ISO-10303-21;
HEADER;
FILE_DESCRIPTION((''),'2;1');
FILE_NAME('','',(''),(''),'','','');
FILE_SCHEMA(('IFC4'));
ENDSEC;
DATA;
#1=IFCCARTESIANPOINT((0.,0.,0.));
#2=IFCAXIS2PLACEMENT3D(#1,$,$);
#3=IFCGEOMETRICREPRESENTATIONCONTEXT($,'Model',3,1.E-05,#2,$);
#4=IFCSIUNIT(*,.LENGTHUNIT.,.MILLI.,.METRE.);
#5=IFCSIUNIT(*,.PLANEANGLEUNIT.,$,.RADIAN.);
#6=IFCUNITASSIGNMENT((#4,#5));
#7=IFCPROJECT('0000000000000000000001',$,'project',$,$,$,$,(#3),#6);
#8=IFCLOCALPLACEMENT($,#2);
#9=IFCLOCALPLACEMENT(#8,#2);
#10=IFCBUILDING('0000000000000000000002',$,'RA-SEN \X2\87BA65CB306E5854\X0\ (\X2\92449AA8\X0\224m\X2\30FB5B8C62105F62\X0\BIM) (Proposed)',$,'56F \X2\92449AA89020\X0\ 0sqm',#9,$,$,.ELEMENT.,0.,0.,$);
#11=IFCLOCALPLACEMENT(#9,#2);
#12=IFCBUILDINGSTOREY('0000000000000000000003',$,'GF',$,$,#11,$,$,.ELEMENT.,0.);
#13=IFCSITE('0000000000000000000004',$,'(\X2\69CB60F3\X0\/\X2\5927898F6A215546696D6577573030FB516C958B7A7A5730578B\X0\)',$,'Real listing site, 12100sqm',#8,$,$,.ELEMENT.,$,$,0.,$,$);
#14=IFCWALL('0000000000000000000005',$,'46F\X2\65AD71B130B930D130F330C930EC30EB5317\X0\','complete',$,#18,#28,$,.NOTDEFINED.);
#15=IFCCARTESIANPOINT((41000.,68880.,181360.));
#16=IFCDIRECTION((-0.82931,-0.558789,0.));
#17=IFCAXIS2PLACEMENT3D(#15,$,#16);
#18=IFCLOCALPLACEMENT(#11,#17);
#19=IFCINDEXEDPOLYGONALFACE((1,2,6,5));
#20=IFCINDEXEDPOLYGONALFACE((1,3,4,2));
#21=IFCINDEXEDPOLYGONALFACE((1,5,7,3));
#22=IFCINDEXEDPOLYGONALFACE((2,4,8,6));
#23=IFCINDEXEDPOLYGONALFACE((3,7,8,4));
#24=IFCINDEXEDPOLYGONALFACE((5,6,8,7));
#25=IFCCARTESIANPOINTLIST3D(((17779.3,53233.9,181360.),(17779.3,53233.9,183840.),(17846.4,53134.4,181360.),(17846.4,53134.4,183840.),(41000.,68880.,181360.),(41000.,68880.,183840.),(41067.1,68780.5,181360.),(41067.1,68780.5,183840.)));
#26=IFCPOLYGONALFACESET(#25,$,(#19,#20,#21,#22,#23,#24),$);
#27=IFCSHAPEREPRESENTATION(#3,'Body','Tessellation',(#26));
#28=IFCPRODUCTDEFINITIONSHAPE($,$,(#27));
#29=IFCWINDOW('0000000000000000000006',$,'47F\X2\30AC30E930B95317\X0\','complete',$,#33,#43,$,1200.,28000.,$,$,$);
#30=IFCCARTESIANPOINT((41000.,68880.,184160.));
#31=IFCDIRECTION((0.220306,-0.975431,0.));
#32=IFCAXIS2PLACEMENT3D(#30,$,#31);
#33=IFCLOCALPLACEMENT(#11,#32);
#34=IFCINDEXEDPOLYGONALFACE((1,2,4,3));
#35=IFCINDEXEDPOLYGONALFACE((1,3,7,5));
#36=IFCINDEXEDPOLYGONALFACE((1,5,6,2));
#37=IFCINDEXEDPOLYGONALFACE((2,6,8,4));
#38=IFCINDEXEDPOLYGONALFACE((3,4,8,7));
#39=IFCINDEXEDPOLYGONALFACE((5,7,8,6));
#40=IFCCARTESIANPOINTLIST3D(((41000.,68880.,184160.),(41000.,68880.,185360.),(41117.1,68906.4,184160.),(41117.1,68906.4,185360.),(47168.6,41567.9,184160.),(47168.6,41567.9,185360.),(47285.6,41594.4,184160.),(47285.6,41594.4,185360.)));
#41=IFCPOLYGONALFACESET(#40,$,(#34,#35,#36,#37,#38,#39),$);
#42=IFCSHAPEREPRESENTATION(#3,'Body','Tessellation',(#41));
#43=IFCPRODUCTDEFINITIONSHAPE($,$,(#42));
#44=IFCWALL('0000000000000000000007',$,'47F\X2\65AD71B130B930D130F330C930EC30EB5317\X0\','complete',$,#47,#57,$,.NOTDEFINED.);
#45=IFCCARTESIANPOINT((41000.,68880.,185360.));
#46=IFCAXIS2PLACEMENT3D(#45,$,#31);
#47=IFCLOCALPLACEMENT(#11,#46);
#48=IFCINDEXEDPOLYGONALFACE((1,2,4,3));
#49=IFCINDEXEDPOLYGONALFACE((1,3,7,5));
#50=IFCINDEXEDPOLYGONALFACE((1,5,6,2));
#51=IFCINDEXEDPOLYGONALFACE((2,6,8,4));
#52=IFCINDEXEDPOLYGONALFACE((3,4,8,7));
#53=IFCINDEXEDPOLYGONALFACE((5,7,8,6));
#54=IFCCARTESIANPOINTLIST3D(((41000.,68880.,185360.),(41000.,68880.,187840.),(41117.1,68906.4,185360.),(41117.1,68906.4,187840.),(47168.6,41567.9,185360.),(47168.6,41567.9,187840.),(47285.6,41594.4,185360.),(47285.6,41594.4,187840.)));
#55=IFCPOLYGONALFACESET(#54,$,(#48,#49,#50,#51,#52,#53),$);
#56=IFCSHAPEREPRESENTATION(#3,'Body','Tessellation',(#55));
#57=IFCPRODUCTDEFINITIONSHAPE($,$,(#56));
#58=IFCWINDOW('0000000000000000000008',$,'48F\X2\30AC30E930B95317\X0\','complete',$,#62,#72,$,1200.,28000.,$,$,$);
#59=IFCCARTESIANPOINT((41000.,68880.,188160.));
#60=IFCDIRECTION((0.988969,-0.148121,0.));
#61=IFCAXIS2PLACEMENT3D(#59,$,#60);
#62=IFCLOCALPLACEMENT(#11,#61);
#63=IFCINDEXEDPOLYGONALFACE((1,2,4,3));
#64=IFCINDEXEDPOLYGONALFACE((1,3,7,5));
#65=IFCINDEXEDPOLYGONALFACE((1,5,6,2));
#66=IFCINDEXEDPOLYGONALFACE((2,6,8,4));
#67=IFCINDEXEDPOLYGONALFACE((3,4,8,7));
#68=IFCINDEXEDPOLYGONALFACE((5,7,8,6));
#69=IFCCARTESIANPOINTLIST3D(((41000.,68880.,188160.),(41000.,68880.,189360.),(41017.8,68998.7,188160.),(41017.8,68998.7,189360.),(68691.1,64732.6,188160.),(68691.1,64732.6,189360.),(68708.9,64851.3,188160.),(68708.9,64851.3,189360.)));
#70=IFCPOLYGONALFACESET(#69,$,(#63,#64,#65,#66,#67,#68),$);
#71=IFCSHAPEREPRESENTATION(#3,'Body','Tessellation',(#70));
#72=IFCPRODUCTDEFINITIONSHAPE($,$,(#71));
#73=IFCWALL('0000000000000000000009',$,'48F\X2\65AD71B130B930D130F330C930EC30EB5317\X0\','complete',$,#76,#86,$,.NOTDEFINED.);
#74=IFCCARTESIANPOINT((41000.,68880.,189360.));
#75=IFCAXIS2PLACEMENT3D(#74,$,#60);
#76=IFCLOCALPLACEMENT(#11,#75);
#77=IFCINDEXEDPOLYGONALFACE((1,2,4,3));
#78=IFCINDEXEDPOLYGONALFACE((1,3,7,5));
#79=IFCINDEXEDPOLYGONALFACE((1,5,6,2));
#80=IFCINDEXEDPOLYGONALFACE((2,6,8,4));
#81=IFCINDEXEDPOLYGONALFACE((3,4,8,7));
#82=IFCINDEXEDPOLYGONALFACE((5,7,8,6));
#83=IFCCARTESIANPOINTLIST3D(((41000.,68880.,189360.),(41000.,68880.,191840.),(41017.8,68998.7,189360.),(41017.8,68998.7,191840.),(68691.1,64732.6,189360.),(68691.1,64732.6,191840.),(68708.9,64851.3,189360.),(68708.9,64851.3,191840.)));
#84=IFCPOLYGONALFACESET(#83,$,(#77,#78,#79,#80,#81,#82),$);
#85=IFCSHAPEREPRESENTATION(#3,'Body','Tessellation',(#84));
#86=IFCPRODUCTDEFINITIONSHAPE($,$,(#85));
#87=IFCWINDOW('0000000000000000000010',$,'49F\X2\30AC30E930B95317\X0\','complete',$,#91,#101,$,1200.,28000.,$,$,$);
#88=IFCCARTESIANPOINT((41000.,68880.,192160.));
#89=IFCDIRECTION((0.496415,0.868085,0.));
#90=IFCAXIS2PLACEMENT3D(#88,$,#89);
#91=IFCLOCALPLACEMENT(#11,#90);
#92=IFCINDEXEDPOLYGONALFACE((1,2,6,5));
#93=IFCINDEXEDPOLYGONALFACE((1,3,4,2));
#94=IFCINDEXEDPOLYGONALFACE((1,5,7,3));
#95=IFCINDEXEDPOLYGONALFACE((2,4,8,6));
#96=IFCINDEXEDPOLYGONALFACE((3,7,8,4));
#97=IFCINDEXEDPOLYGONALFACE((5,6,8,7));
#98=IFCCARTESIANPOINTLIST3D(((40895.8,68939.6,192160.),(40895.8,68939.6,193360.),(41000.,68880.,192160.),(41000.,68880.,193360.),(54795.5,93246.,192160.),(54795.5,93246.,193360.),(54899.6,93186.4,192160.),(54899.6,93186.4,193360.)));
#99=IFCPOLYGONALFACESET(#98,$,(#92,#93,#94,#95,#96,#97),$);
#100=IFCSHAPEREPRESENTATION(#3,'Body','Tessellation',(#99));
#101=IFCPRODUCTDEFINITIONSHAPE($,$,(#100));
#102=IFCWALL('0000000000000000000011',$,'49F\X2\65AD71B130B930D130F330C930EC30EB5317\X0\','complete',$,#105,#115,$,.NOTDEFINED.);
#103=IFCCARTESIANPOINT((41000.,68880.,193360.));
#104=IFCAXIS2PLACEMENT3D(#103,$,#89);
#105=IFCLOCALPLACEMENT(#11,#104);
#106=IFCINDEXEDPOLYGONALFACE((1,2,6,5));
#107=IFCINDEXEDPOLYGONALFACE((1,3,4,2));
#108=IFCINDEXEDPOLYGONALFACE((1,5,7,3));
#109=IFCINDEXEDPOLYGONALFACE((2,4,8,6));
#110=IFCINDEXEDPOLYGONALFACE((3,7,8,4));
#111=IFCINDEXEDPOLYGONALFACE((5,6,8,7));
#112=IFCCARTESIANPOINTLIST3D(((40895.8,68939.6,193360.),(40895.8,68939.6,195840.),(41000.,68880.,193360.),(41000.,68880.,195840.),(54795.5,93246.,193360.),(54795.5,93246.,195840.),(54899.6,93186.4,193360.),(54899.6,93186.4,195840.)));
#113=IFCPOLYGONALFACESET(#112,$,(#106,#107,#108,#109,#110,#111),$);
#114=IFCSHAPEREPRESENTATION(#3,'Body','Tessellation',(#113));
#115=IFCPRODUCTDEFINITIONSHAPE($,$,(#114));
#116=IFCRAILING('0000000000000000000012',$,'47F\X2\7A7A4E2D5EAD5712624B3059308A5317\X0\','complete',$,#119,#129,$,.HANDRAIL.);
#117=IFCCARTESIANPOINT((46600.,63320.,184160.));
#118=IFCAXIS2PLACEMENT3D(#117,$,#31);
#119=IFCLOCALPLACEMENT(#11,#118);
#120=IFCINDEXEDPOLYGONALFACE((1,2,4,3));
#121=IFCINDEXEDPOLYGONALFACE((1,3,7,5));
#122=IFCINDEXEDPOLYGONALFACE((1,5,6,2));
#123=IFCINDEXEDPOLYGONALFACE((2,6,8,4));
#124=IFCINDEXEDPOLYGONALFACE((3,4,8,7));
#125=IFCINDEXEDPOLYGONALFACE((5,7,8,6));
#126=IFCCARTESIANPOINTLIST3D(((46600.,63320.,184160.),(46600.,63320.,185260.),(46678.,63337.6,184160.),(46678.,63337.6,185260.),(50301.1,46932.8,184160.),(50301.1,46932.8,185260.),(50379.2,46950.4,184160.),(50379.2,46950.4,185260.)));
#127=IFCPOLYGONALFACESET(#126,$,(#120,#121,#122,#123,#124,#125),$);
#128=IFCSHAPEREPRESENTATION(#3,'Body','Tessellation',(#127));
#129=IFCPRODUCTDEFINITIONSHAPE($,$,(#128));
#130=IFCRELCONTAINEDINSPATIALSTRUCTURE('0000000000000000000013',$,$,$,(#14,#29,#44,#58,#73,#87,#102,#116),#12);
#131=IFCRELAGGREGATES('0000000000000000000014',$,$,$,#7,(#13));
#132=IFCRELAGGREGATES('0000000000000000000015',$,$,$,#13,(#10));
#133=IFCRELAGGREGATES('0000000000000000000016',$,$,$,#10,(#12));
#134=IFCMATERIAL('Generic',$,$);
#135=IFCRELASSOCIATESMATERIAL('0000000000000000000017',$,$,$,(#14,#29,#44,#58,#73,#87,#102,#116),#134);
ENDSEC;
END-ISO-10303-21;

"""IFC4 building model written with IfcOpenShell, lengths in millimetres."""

from ifc_helpers import new_model, si_unit, frame, frame_2d, origin, place, context, project, spatial, rectangle, extrude, material, element, save


model = new_model("IFC4")

# Units and contexts
model_context = context("Model", 3, precision=1e-05, world=origin())
ifc_project = project(units=[si_unit("LENGTHUNIT", "METRE", prefix="MILLI"), si_unit("PLANEANGLEUNIT", "RADIAN")], contexts=[model_context])

# Site, building, storey
site_placement = place(None, origin())
site = spatial("IfcSite", under=ifc_project, at=site_placement, Name="(構想/大規模商業敷地・公開空地型)", ObjectType="Real listing site, 12100sqm", CompositionType="ELEMENT", RefElevation=0.0)
building_placement = place(site_placement, origin())
building = spatial("IfcBuilding", under=site, at=building_placement, Name="RA-SEN 螺旋の塔 (鉄骨224m・完成形BIM) (Proposed)", ObjectType="56F 鉄骨造 0sqm", CompositionType="ELEMENT", ElevationOfRefHeight=0.0, ElevationOfTerrain=0.0)
storey_placement = place(building_placement, origin())
storey = spatial("IfcBuildingStorey", under=building, at=storey_placement, Name="GF", CompositionType="ELEMENT", Elevation=0.0)

# Shared definitions
ifc_material = material(Name="Generic")

# Wall
wall_1_placement = place(storey_placement, frame((41000.0, 68880.0, 181360.0), x_axis=(-0.82931, -0.558789, 0.0)))
element("IfcWall", 1, at=wall_1_placement, inside=storey, material=ifc_material, Name="46F断熱スパンドレル北", Description="complete", PredefinedType="NOTDEFINED", context=model_context, shape_type="SweptSolid", body=[
    extrude(rectangle(XDim=28000.0, YDim=120.0, at=frame_2d((14000.0, 60.0))), frame((41000.0, 68880.0, 181360.0), x_axis=(-0.82931, -0.558789, 0.0)), (0.0, 0.0, 1.0), 2480.0),
])

# Window
window_1_placement = place(storey_placement, frame((41000.0, 68880.0, 184160.0), x_axis=(0.220306, -0.975431, 0.0)))
element("IfcWindow", 2, at=window_1_placement, inside=storey, material=ifc_material, Name="47Fガラス北", Description="complete", OverallHeight=1200.0, OverallWidth=28000.0, context=model_context, shape_type="SweptSolid", body=[
    extrude(rectangle(XDim=28000.0, YDim=120.0, at=frame_2d((14000.0, 60.0))), frame((41000.0, 68880.0, 184160.0), x_axis=(0.220306, -0.975431, 0.0)), (0.0, 0.0, 1.0), 1200.0),
])

# Wall
wall_2_placement = place(storey_placement, frame((41000.0, 68880.0, 185360.0), x_axis=(0.220306, -0.975431, 0.0)))
element("IfcWall", 3, at=wall_2_placement, inside=storey, material=ifc_material, Name="47F断熱スパンドレル北", Description="complete", PredefinedType="NOTDEFINED", context=model_context, shape_type="SweptSolid", body=[
    extrude(rectangle(XDim=28000.0, YDim=120.0, at=frame_2d((14000.0, 60.0))), frame((41000.0, 68880.0, 185360.0), x_axis=(0.220306, -0.975431, 0.0)), (0.0, 0.0, 1.0), 2480.0),
])

# Window
window_2_placement = place(storey_placement, frame((41000.0, 68880.0, 188160.0), x_axis=(0.988969, -0.148121, 0.0)))
element("IfcWindow", 4, at=window_2_placement, inside=storey, material=ifc_material, Name="48Fガラス北", Description="complete", OverallHeight=1200.0, OverallWidth=28000.0, context=model_context, shape_type="SweptSolid", body=[
    extrude(rectangle(XDim=28000.0, YDim=120.0, at=frame_2d((14000.0, 60.0))), frame((41000.0, 68880.0, 188160.0), x_axis=(0.988969, -0.148121, 0.0)), (0.0, 0.0, 1.0), 1200.0),
])

# Wall
wall_3_placement = place(storey_placement, frame((41000.0, 68880.0, 189360.0), x_axis=(0.988969, -0.148121, 0.0)))
element("IfcWall", 5, at=wall_3_placement, inside=storey, material=ifc_material, Name="48F断熱スパンドレル北", Description="complete", PredefinedType="NOTDEFINED", context=model_context, shape_type="SweptSolid", body=[
    extrude(rectangle(XDim=28000.0, YDim=120.0, at=frame_2d((14000.0, 60.0))), frame((41000.0, 68880.0, 189360.0), x_axis=(0.988969, -0.148121, 0.0)), (0.0, 0.0, 1.0), 2480.0),
])

# Window
window_3_placement = place(storey_placement, frame((41000.0, 68880.0, 192160.0), x_axis=(0.496415, 0.868085, 0.0)))
element("IfcWindow", 6, at=window_3_placement, inside=storey, material=ifc_material, Name="49Fガラス北", Description="complete", OverallHeight=1200.0, OverallWidth=28000.0, context=model_context, shape_type="SweptSolid", body=[
    extrude(rectangle(XDim=28000.0, YDim=120.0, at=frame_2d((14000.0, 60.0))), frame((41000.0, 68880.0, 192160.0), x_axis=(0.496415, 0.868085, 0.0)), (0.0, 0.0, 1.0), 1200.0),
])

# Wall
wall_4_placement = place(storey_placement, frame((41000.0, 68880.0, 193360.0), x_axis=(0.496415, 0.868085, 0.0)))
element("IfcWall", 7, at=wall_4_placement, inside=storey, material=ifc_material, Name="49F断熱スパンドレル北", Description="complete", PredefinedType="NOTDEFINED", context=model_context, shape_type="SweptSolid", body=[
    extrude(rectangle(XDim=28000.0, YDim=120.0, at=frame_2d((14000.0, 60.0))), frame((41000.0, 68880.0, 193360.0), x_axis=(0.496415, 0.868085, 0.0)), (0.0, 0.0, 1.0), 2480.0),
])

# Railing
railing_placement = place(storey_placement, frame((46600.0, 63320.0, 184160.0), x_axis=(0.220306, -0.975431, 0.0)))
element("IfcRailing", 8, at=railing_placement, inside=storey, material=ifc_material, Name="47F空中庭園手すり北", Description="complete", PredefinedType="HANDRAIL", context=model_context, shape_type="SweptSolid", body=[
    extrude(rectangle(XDim=16800.0, YDim=80.0, at=frame_2d((8400.0, 40.0))), frame((46600.0, 63320.0, 184160.0), x_axis=(0.220306, -0.975431, 0.0)), (0.0, 0.0, 1.0), 1100.0),
])

save(model, "model.ifc")
